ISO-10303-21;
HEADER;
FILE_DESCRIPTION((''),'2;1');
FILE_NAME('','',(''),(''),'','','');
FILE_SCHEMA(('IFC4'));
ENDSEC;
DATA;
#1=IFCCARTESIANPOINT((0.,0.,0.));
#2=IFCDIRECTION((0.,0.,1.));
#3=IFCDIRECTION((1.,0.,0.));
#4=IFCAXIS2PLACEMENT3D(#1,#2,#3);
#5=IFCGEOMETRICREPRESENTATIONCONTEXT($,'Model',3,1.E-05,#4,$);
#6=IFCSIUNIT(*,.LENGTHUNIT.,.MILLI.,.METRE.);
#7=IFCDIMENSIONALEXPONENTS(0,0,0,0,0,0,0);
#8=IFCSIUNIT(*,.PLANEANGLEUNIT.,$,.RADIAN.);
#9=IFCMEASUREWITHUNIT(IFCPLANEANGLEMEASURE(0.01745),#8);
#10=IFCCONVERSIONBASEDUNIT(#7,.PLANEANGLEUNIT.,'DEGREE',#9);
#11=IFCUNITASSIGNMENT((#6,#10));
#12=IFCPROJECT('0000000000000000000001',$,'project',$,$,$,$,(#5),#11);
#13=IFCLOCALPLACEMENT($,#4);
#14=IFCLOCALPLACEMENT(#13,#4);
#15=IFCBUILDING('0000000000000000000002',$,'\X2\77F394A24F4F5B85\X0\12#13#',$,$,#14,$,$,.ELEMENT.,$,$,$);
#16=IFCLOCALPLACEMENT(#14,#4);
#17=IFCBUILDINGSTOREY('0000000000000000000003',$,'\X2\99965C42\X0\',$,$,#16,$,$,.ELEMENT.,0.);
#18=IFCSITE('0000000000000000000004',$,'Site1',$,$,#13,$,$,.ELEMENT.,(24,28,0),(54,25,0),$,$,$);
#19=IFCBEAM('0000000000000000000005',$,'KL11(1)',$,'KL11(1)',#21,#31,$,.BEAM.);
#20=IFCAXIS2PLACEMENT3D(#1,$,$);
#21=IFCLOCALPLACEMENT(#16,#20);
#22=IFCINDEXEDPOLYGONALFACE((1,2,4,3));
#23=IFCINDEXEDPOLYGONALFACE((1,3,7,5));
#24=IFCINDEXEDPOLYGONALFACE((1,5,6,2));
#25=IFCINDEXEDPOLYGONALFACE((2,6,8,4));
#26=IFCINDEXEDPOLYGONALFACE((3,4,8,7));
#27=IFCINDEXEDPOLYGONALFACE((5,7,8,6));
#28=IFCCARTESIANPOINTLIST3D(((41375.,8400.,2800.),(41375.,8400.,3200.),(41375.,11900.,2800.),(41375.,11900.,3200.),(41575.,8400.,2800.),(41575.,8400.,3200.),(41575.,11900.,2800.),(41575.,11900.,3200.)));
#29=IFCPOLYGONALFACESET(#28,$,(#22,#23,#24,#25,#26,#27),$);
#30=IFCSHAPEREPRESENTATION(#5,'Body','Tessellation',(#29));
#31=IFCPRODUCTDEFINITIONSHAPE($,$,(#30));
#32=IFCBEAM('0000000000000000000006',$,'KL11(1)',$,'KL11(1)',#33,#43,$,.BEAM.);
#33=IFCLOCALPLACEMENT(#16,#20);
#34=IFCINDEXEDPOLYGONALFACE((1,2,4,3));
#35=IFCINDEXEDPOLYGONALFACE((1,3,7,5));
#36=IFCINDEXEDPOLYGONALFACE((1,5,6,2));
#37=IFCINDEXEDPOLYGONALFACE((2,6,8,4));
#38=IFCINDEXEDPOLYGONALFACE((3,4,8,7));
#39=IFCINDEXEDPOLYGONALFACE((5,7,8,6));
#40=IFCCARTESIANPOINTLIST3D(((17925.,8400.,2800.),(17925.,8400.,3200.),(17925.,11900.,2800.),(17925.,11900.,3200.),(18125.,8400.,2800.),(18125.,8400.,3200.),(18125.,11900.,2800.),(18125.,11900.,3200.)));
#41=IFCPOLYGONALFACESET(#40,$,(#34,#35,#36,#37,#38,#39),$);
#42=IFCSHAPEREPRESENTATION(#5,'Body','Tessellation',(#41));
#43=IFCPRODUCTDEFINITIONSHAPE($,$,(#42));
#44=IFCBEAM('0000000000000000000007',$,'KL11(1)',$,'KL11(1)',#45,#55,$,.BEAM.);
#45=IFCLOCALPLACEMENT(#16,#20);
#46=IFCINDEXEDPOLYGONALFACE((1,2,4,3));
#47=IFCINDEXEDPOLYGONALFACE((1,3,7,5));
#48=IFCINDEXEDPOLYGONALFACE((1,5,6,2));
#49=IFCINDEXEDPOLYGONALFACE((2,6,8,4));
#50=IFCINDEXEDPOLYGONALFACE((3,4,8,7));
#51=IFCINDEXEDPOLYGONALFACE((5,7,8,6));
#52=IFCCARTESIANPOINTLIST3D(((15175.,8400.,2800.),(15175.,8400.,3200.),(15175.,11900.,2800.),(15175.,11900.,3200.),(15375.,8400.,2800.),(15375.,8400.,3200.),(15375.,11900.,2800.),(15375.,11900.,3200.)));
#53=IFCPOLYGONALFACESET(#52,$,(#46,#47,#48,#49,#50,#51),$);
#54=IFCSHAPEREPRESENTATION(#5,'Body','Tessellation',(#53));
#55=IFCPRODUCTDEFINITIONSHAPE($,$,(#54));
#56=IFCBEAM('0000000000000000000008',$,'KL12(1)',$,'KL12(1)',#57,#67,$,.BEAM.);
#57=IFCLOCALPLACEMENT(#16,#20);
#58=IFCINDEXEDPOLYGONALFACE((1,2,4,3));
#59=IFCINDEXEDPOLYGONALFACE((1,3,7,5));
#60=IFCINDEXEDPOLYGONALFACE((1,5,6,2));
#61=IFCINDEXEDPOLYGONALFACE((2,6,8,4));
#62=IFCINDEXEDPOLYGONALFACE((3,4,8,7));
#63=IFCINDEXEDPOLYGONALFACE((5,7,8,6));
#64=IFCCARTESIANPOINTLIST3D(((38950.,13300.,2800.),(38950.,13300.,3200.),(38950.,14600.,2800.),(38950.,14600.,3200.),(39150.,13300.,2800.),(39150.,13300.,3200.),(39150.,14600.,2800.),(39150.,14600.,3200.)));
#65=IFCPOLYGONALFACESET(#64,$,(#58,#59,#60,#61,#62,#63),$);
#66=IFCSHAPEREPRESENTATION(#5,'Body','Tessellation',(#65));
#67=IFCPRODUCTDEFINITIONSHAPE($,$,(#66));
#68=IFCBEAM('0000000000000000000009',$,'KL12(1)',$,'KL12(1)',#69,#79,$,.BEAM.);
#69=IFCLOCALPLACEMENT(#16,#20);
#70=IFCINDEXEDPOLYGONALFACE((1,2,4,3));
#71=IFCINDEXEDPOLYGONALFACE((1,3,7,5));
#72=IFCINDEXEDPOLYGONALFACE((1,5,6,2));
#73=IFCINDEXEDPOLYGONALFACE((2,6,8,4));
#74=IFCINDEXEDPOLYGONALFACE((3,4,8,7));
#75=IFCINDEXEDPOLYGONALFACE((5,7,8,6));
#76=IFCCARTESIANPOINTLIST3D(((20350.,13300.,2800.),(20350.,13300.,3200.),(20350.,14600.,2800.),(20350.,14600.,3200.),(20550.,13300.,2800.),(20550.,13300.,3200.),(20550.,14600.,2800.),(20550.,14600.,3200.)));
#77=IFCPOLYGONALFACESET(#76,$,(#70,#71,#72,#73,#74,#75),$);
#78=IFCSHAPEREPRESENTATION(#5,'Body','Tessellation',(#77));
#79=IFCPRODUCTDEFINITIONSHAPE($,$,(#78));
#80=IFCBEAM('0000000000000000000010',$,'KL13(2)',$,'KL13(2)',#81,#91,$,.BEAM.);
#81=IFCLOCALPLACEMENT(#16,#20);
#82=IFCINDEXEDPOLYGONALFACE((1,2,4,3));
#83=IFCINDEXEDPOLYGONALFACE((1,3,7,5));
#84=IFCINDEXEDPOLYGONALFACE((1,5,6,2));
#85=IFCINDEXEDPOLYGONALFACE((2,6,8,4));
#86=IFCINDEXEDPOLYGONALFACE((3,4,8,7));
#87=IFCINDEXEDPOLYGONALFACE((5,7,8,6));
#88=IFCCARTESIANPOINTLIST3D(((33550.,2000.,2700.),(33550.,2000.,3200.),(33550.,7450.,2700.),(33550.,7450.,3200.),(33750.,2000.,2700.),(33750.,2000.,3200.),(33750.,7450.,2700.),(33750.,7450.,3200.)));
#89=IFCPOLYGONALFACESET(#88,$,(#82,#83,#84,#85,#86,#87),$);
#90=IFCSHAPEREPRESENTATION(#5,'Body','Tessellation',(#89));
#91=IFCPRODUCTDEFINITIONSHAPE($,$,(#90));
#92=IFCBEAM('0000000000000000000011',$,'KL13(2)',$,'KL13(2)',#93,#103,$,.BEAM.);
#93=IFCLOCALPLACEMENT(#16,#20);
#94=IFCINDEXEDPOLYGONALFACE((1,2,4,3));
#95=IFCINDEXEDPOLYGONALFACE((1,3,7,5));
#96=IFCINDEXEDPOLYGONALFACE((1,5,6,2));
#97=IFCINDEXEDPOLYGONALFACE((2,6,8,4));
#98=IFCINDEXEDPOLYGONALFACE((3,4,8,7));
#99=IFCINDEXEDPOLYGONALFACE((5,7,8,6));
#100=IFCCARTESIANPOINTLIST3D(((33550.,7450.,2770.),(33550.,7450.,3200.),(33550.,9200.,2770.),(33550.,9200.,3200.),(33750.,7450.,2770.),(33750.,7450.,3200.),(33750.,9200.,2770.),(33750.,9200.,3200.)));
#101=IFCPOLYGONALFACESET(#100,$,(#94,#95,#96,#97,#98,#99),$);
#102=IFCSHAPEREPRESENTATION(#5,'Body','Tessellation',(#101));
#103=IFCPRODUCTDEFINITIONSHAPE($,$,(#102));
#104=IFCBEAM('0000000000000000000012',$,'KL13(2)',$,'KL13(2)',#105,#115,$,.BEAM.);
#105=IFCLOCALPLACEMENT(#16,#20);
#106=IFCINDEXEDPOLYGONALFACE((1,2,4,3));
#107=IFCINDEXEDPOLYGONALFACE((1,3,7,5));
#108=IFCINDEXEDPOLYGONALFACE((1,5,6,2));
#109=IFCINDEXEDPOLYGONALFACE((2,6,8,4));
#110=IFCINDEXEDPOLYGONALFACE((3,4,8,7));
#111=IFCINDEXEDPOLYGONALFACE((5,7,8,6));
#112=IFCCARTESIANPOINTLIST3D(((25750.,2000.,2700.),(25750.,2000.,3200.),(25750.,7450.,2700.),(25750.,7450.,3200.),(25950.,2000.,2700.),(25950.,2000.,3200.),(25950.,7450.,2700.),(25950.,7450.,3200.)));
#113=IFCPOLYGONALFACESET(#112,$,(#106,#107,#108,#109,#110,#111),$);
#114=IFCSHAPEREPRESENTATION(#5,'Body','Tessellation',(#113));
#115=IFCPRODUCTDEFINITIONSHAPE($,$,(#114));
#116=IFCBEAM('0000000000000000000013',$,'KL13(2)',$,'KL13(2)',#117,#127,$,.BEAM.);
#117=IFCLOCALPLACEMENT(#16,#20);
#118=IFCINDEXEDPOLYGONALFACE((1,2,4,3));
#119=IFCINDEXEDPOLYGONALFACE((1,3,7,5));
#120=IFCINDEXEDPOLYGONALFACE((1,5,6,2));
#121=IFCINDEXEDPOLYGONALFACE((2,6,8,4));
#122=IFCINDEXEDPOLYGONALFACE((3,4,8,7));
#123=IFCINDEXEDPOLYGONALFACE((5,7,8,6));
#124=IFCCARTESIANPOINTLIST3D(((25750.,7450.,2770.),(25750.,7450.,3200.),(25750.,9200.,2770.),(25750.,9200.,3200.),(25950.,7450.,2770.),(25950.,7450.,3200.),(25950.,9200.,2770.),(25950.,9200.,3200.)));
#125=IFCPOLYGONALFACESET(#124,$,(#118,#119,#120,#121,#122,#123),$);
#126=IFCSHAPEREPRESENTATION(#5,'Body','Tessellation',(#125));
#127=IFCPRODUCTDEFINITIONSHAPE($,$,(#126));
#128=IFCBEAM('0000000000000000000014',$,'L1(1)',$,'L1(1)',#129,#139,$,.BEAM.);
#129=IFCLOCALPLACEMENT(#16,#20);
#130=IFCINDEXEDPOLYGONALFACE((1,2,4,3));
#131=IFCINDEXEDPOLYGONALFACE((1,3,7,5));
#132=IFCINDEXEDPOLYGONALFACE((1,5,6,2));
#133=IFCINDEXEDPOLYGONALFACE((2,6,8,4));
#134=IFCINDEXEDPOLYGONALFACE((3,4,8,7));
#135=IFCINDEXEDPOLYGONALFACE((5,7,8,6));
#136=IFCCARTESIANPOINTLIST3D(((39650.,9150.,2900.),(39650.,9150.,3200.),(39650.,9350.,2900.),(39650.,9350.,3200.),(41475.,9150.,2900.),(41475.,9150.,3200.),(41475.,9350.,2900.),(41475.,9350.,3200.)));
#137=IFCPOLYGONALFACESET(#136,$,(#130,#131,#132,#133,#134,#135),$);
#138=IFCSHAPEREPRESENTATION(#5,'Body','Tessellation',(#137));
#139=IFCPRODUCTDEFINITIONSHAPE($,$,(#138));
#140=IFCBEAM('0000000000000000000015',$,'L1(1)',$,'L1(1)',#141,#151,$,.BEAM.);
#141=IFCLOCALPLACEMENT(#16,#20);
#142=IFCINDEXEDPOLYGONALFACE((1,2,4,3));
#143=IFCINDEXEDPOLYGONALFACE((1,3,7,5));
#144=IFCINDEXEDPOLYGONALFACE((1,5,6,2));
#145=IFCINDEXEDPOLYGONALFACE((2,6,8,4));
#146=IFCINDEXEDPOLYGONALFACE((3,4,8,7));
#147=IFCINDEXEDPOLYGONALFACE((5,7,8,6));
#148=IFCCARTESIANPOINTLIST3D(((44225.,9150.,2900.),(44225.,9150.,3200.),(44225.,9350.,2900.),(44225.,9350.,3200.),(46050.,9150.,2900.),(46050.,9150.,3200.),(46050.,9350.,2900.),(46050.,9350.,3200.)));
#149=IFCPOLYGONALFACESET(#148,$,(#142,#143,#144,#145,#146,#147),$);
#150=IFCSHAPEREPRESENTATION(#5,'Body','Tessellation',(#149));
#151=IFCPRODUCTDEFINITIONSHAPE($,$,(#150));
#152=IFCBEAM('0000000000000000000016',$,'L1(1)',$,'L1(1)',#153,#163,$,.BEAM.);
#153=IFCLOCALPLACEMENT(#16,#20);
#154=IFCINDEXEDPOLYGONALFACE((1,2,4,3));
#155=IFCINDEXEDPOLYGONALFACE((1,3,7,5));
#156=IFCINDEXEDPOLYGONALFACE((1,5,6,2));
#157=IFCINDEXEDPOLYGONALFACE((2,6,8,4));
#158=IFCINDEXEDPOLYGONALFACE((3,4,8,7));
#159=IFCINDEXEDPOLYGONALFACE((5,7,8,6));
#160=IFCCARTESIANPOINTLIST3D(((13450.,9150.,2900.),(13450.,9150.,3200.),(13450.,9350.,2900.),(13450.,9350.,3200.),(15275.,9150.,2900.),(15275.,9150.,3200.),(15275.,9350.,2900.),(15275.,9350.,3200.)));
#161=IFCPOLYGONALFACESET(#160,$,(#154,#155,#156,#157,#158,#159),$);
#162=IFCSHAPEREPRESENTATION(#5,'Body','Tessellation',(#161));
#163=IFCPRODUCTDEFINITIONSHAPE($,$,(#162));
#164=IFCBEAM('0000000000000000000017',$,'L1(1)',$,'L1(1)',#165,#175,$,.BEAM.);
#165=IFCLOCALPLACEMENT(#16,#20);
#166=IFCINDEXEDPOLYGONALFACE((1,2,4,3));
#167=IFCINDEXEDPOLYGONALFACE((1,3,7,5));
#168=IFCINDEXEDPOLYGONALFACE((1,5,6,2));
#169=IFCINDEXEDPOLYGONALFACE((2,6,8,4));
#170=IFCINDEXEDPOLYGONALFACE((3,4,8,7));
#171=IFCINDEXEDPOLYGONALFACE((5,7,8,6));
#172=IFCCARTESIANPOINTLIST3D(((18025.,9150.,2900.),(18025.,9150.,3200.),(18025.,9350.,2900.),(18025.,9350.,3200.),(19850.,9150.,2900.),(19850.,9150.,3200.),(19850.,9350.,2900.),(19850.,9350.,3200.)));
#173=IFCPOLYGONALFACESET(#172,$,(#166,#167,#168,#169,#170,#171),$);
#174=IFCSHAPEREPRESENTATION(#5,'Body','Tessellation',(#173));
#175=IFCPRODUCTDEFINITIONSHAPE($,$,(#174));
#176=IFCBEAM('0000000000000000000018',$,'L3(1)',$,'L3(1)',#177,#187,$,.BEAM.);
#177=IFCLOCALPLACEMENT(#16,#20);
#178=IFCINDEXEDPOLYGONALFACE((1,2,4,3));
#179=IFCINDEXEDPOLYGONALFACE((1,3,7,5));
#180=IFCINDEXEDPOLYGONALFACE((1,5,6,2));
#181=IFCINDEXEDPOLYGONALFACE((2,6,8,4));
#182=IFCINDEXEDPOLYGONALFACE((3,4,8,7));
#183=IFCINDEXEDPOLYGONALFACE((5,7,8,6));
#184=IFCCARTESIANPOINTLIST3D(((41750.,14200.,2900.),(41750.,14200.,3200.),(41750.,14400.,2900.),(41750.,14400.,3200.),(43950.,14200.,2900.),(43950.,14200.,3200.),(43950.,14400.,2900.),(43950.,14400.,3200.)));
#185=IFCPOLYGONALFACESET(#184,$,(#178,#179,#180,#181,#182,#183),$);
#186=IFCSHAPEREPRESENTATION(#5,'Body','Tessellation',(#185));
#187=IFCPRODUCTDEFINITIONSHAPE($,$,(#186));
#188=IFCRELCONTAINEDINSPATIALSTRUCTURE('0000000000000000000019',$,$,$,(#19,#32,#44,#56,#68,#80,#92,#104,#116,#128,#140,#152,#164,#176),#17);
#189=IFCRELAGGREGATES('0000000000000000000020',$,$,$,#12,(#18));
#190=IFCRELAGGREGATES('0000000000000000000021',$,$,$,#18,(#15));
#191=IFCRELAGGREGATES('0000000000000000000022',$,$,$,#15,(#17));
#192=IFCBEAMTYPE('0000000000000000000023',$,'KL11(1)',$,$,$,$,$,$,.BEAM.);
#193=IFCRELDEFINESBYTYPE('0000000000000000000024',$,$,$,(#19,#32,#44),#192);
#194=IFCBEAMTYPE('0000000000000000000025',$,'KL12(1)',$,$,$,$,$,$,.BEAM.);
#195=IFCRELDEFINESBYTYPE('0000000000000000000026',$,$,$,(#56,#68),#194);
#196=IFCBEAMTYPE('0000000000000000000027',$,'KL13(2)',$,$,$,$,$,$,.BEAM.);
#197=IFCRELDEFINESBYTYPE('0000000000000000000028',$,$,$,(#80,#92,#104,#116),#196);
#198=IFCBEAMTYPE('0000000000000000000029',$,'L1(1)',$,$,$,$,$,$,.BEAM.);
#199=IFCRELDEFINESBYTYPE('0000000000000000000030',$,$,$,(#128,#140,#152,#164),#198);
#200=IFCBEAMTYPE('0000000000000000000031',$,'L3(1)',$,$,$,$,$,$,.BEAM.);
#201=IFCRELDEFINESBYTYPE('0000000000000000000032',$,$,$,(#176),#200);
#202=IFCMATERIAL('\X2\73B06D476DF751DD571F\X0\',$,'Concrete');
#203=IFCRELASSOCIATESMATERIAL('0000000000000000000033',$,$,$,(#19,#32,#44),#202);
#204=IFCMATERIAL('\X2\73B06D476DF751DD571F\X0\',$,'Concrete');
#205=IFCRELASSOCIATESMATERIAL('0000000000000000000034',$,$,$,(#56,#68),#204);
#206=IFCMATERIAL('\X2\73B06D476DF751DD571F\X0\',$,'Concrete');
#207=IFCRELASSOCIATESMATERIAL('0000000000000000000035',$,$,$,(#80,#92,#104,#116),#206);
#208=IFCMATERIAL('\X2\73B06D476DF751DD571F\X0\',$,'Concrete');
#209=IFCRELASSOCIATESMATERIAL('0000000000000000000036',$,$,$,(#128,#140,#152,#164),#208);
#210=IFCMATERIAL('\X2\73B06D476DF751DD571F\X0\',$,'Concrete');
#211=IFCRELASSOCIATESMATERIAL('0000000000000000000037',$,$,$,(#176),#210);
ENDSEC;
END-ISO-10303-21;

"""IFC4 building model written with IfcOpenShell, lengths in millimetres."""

from ifc_helpers import new_model, entity, si_unit, converted_unit, frame, origin_with_axes, place, context, project, spatial, polyline, outline, extrude, material, type_object, element, save


model = new_model("IFC4")

# Units and contexts
model_context = context("Model", 3, precision=1e-05, world=origin_with_axes())
ifc_project = project(units=[si_unit("LENGTHUNIT", "METRE", prefix="MILLI"), converted_unit("PLANEANGLEUNIT", "DEGREE", entity("IfcPlaneAngleMeasure", 0.01745), si_unit("PLANEANGLEUNIT", "RADIAN"), dimensions=[0, 0, 0, 0, 0, 0, 0])], contexts=[model_context])

# Site, building, storey
site_placement = place(None, origin_with_axes())
site = spatial("IfcSite", under=ifc_project, at=site_placement, Name="Site1", CompositionType="ELEMENT", RefLatitude=(24, 28, 0), RefLongitude=(54, 25, 0))
building_placement = place(site_placement, origin_with_axes())
building = spatial("IfcBuilding", under=site, at=building_placement, Name="石钢住宅12#13#", CompositionType="ELEMENT")
storey_placement = place(building_placement, origin_with_axes())
storey = spatial("IfcBuildingStorey", under=building, at=storey_placement, Name="首层", CompositionType="ELEMENT", Elevation=0.0)

# Beams
ifc_material_1 = material(Name="现浇混凝土", Category="Concrete")
beam_type_1 = type_object("IfcBeamType", Name="KL11(1)", PredefinedType="BEAM")
beam_1_placement = place(storey_placement, origin_with_axes())
element("IfcBeam", 1, at=beam_1_placement, inside=storey, type_object=beam_type_1, material=ifc_material_1, Name="KL11(1)", ObjectType="KL11(1)", PredefinedType="BEAM", context=model_context, shape_type="SweptSolid", body=[
    extrude(outline(polyline([(0.0, 0.0), (200.0, 0.0), (200.0, 400.0), (0.0, 400.0), (0.0, 0.0)])), frame((41575.0, 8400.0, 2800.0), z_axis=(0.0, 1.0, 0.0), x_axis=(-1.0, 0.0, 0.0)), (0.0, 0.0, 1.0), 3500.0),
])
beam_2_placement = place(storey_placement, origin_with_axes())
element("IfcBeam", 2, at=beam_2_placement, inside=storey, type_object=beam_type_1, material=ifc_material_1, Name="KL11(1)", ObjectType="KL11(1)", PredefinedType="BEAM", context=model_context, shape_type="SweptSolid", body=[
    extrude(outline(polyline([(0.0, 0.0), (400.0, 0.0), (400.0, 200.0), (0.0, 200.0), (0.0, 0.0)])), frame((17925.0, 8400.0, 2800.0), z_axis=(0.0, 1.0, 0.0), x_axis=(0.0, 0.0, 1.0)), (0.0, 0.0, 1.0), 3500.0),
])
beam_3_placement = place(storey_placement, origin_with_axes())
element("IfcBeam", 3, at=beam_3_placement, inside=storey, type_object=beam_type_1, material=ifc_material_1, Name="KL11(1)", ObjectType="KL11(1)", PredefinedType="BEAM", context=model_context, shape_type="SweptSolid", body=[
    extrude(outline(polyline([(0.0, 0.0), (400.0, 0.0), (400.0, 200.0), (0.0, 200.0), (0.0, 0.0)])), frame((15175.0, 8400.0, 2800.0), z_axis=(0.0, 1.0, 0.0), x_axis=(0.0, 0.0, 1.0)), (0.0, 0.0, 1.0), 3500.0),
])
ifc_material_2 = material(Name="现浇混凝土", Category="Concrete")
beam_type_2 = type_object("IfcBeamType", Name="KL12(1)", PredefinedType="BEAM")
beam_4_placement = place(storey_placement, origin_with_axes())
element("IfcBeam", 4, at=beam_4_placement, inside=storey, type_object=beam_type_2, material=ifc_material_2, Name="KL12(1)", ObjectType="KL12(1)", PredefinedType="BEAM", context=model_context, shape_type="SweptSolid", body=[
    extrude(outline(polyline([(0.0, 0.0), (200.0, 0.0), (200.0, 400.0), (0.0, 400.0), (0.0, 0.0)])), frame((39150.0, 13300.0, 2800.0), z_axis=(0.0, 1.0, 0.0), x_axis=(-1.0, 0.0, 0.0)), (0.0, 0.0, 1.0), 1300.0),
])
beam_5_placement = place(storey_placement, origin_with_axes())
element("IfcBeam", 5, at=beam_5_placement, inside=storey, type_object=beam_type_2, material=ifc_material_2, Name="KL12(1)", ObjectType="KL12(1)", PredefinedType="BEAM", context=model_context, shape_type="SweptSolid", body=[
    extrude(outline(polyline([(0.0, 0.0), (400.0, 0.0), (400.0, 200.0), (0.0, 200.0), (0.0, 0.0)])), frame((20350.0, 13300.0, 2800.0), z_axis=(0.0, 1.0, 0.0), x_axis=(0.0, 0.0, 1.0)), (0.0, 0.0, 1.0), 1300.0),
])
ifc_material_3 = material(Name="现浇混凝土", Category="Concrete")
beam_type_3 = type_object("IfcBeamType", Name="KL13(2)", PredefinedType="BEAM")
beam_6_placement = place(storey_placement, origin_with_axes())
element("IfcBeam", 6, at=beam_6_placement, inside=storey, type_object=beam_type_3, material=ifc_material_3, Name="KL13(2)", ObjectType="KL13(2)", PredefinedType="BEAM", context=model_context, shape_type="SweptSolid", body=[
    extrude(outline(polyline([(0.0, 0.0), (200.0, 0.0), (200.0, 500.0), (0.0, 500.0), (0.0, 0.0)])), frame((33750.0, 2000.0, 2700.0), z_axis=(0.0, 1.0, 0.0), x_axis=(-1.0, 0.0, 0.0)), (0.0, 0.0, 1.0), 5450.0),
])
beam_7_placement = place(storey_placement, origin_with_axes())
element("IfcBeam", 7, at=beam_7_placement, inside=storey, type_object=beam_type_3, material=ifc_material_3, Name="KL13(2)", ObjectType="KL13(2)", PredefinedType="BEAM", context=model_context, shape_type="SweptSolid", body=[
    extrude(outline(polyline([(0.0, 0.0), (200.0, 0.0), (200.0, 430.0), (0.0, 430.0), (0.0, 0.0)])), frame((33750.0, 7450.0, 2770.0), z_axis=(0.0, 1.0, 0.0), x_axis=(-1.0, 0.0, 0.0)), (0.0, 0.0, 1.0), 1750.0),
])
beam_8_placement = place(storey_placement, origin_with_axes())
element("IfcBeam", 8, at=beam_8_placement, inside=storey, type_object=beam_type_3, material=ifc_material_3, Name="KL13(2)", ObjectType="KL13(2)", PredefinedType="BEAM", context=model_context, shape_type="SweptSolid", body=[
    extrude(outline(polyline([(0.0, 0.0), (500.0, 0.0), (500.0, 200.0), (0.0, 200.0), (0.0, 0.0)])), frame((25750.0, 2000.0, 2700.0), z_axis=(0.0, 1.0, 0.0), x_axis=(0.0, 0.0, 1.0)), (0.0, 0.0, 1.0), 5450.0),
])
beam_9_placement = place(storey_placement, origin_with_axes())
element("IfcBeam", 9, at=beam_9_placement, inside=storey, type_object=beam_type_3, material=ifc_material_3, Name="KL13(2)", ObjectType="KL13(2)", PredefinedType="BEAM", context=model_context, shape_type="SweptSolid", body=[
    extrude(outline(polyline([(0.0, 0.0), (430.0, 0.0), (430.0, 200.0), (0.0, 200.0), (0.0, 0.0)])), frame((25750.0, 7450.0, 2770.0), z_axis=(0.0, 1.0, 0.0), x_axis=(0.0, 0.0, 1.0)), (0.0, 0.0, 1.0), 1750.0),
])
ifc_material_4 = material(Name="现浇混凝土", Category="Concrete")
beam_type_4 = type_object("IfcBeamType", Name="L1(1)", PredefinedType="BEAM")
beam_10_placement = place(storey_placement, origin_with_axes())
element("IfcBeam", 10, at=beam_10_placement, inside=storey, type_object=beam_type_4, material=ifc_material_4, Name="L1(1)", ObjectType="L1(1)", PredefinedType="BEAM", context=model_context, shape_type="SweptSolid", body=[
    extrude(outline(polyline([(0.0, 0.0), (200.0, 0.0), (200.0, 300.0), (0.0, 300.0), (0.0, 0.0)])), frame((41475.0, 9350.0, 2900.0), z_axis=(-1.0, 0.0, 0.0), x_axis=(0.0, -1.0, 0.0)), (0.0, 0.0, 1.0), 1825.0),
])
beam_11_placement = place(storey_placement, origin_with_axes())
element("IfcBeam", 11, at=beam_11_placement, inside=storey, type_object=beam_type_4, material=ifc_material_4, Name="L1(1)", ObjectType="L1(1)", PredefinedType="BEAM", context=model_context, shape_type="SweptSolid", body=[
    extrude(outline(polyline([(0.0, 0.0), (200.0, 0.0), (200.0, 300.0), (0.0, 300.0), (0.0, 0.0)])), frame((46050.0, 9350.0, 2900.0), z_axis=(-1.0, 0.0, 0.0), x_axis=(0.0, -1.0, 0.0)), (0.0, 0.0, 1.0), 1825.0),
])
beam_12_placement = place(storey_placement, origin_with_axes())
element("IfcBeam", 12, at=beam_12_placement, inside=storey, type_object=beam_type_4, material=ifc_material_4, Name="L1(1)", ObjectType="L1(1)", PredefinedType="BEAM", context=model_context, shape_type="SweptSolid", body=[
    extrude(outline(polyline([(0.0, 0.0), (300.0, 0.0), (300.0, 200.0), (0.0, 200.0), (0.0, 0.0)])), frame((13450.0, 9350.0, 2900.0), z_axis=(1.0, 0.0, 0.0), x_axis=(0.0, 0.0, 1.0)), (0.0, 0.0, 1.0), 1825.0),
])
beam_13_placement = place(storey_placement, origin_with_axes())
element("IfcBeam", 13, at=beam_13_placement, inside=storey, type_object=beam_type_4, material=ifc_material_4, Name="L1(1)", ObjectType="L1(1)", PredefinedType="BEAM", context=model_context, shape_type="SweptSolid", body=[
    extrude(outline(polyline([(0.0, 0.0), (300.0, 0.0), (300.0, 200.0), (0.0, 200.0), (0.0, 0.0)])), frame((18025.0, 9350.0, 2900.0), z_axis=(1.0, 0.0, 0.0), x_axis=(0.0, 0.0, 1.0)), (0.0, 0.0, 1.0), 1825.0),
])
ifc_material_5 = material(Name="现浇混凝土", Category="Concrete")
beam_type_5 = type_object("IfcBeamType", Name="L3(1)", PredefinedType="BEAM")
beam_14_placement = place(storey_placement, origin_with_axes())
element("IfcBeam", 14, at=beam_14_placement, inside=storey, type_object=beam_type_5, material=ifc_material_5, Name="L3(1)", ObjectType="L3(1)", PredefinedType="BEAM", context=model_context, shape_type="SweptSolid", body=[
    extrude(outline(polyline([(0.0, 0.0), (200.0, 0.0), (200.0, 300.0), (0.0, 300.0), (0.0, 0.0)])), frame((43950.0, 14400.0, 2900.0), z_axis=(-1.0, 0.0, 0.0), x_axis=(0.0, -1.0, 0.0)), (0.0, 0.0, 1.0), 2200.0),
])

save(model, "model.ifc")
